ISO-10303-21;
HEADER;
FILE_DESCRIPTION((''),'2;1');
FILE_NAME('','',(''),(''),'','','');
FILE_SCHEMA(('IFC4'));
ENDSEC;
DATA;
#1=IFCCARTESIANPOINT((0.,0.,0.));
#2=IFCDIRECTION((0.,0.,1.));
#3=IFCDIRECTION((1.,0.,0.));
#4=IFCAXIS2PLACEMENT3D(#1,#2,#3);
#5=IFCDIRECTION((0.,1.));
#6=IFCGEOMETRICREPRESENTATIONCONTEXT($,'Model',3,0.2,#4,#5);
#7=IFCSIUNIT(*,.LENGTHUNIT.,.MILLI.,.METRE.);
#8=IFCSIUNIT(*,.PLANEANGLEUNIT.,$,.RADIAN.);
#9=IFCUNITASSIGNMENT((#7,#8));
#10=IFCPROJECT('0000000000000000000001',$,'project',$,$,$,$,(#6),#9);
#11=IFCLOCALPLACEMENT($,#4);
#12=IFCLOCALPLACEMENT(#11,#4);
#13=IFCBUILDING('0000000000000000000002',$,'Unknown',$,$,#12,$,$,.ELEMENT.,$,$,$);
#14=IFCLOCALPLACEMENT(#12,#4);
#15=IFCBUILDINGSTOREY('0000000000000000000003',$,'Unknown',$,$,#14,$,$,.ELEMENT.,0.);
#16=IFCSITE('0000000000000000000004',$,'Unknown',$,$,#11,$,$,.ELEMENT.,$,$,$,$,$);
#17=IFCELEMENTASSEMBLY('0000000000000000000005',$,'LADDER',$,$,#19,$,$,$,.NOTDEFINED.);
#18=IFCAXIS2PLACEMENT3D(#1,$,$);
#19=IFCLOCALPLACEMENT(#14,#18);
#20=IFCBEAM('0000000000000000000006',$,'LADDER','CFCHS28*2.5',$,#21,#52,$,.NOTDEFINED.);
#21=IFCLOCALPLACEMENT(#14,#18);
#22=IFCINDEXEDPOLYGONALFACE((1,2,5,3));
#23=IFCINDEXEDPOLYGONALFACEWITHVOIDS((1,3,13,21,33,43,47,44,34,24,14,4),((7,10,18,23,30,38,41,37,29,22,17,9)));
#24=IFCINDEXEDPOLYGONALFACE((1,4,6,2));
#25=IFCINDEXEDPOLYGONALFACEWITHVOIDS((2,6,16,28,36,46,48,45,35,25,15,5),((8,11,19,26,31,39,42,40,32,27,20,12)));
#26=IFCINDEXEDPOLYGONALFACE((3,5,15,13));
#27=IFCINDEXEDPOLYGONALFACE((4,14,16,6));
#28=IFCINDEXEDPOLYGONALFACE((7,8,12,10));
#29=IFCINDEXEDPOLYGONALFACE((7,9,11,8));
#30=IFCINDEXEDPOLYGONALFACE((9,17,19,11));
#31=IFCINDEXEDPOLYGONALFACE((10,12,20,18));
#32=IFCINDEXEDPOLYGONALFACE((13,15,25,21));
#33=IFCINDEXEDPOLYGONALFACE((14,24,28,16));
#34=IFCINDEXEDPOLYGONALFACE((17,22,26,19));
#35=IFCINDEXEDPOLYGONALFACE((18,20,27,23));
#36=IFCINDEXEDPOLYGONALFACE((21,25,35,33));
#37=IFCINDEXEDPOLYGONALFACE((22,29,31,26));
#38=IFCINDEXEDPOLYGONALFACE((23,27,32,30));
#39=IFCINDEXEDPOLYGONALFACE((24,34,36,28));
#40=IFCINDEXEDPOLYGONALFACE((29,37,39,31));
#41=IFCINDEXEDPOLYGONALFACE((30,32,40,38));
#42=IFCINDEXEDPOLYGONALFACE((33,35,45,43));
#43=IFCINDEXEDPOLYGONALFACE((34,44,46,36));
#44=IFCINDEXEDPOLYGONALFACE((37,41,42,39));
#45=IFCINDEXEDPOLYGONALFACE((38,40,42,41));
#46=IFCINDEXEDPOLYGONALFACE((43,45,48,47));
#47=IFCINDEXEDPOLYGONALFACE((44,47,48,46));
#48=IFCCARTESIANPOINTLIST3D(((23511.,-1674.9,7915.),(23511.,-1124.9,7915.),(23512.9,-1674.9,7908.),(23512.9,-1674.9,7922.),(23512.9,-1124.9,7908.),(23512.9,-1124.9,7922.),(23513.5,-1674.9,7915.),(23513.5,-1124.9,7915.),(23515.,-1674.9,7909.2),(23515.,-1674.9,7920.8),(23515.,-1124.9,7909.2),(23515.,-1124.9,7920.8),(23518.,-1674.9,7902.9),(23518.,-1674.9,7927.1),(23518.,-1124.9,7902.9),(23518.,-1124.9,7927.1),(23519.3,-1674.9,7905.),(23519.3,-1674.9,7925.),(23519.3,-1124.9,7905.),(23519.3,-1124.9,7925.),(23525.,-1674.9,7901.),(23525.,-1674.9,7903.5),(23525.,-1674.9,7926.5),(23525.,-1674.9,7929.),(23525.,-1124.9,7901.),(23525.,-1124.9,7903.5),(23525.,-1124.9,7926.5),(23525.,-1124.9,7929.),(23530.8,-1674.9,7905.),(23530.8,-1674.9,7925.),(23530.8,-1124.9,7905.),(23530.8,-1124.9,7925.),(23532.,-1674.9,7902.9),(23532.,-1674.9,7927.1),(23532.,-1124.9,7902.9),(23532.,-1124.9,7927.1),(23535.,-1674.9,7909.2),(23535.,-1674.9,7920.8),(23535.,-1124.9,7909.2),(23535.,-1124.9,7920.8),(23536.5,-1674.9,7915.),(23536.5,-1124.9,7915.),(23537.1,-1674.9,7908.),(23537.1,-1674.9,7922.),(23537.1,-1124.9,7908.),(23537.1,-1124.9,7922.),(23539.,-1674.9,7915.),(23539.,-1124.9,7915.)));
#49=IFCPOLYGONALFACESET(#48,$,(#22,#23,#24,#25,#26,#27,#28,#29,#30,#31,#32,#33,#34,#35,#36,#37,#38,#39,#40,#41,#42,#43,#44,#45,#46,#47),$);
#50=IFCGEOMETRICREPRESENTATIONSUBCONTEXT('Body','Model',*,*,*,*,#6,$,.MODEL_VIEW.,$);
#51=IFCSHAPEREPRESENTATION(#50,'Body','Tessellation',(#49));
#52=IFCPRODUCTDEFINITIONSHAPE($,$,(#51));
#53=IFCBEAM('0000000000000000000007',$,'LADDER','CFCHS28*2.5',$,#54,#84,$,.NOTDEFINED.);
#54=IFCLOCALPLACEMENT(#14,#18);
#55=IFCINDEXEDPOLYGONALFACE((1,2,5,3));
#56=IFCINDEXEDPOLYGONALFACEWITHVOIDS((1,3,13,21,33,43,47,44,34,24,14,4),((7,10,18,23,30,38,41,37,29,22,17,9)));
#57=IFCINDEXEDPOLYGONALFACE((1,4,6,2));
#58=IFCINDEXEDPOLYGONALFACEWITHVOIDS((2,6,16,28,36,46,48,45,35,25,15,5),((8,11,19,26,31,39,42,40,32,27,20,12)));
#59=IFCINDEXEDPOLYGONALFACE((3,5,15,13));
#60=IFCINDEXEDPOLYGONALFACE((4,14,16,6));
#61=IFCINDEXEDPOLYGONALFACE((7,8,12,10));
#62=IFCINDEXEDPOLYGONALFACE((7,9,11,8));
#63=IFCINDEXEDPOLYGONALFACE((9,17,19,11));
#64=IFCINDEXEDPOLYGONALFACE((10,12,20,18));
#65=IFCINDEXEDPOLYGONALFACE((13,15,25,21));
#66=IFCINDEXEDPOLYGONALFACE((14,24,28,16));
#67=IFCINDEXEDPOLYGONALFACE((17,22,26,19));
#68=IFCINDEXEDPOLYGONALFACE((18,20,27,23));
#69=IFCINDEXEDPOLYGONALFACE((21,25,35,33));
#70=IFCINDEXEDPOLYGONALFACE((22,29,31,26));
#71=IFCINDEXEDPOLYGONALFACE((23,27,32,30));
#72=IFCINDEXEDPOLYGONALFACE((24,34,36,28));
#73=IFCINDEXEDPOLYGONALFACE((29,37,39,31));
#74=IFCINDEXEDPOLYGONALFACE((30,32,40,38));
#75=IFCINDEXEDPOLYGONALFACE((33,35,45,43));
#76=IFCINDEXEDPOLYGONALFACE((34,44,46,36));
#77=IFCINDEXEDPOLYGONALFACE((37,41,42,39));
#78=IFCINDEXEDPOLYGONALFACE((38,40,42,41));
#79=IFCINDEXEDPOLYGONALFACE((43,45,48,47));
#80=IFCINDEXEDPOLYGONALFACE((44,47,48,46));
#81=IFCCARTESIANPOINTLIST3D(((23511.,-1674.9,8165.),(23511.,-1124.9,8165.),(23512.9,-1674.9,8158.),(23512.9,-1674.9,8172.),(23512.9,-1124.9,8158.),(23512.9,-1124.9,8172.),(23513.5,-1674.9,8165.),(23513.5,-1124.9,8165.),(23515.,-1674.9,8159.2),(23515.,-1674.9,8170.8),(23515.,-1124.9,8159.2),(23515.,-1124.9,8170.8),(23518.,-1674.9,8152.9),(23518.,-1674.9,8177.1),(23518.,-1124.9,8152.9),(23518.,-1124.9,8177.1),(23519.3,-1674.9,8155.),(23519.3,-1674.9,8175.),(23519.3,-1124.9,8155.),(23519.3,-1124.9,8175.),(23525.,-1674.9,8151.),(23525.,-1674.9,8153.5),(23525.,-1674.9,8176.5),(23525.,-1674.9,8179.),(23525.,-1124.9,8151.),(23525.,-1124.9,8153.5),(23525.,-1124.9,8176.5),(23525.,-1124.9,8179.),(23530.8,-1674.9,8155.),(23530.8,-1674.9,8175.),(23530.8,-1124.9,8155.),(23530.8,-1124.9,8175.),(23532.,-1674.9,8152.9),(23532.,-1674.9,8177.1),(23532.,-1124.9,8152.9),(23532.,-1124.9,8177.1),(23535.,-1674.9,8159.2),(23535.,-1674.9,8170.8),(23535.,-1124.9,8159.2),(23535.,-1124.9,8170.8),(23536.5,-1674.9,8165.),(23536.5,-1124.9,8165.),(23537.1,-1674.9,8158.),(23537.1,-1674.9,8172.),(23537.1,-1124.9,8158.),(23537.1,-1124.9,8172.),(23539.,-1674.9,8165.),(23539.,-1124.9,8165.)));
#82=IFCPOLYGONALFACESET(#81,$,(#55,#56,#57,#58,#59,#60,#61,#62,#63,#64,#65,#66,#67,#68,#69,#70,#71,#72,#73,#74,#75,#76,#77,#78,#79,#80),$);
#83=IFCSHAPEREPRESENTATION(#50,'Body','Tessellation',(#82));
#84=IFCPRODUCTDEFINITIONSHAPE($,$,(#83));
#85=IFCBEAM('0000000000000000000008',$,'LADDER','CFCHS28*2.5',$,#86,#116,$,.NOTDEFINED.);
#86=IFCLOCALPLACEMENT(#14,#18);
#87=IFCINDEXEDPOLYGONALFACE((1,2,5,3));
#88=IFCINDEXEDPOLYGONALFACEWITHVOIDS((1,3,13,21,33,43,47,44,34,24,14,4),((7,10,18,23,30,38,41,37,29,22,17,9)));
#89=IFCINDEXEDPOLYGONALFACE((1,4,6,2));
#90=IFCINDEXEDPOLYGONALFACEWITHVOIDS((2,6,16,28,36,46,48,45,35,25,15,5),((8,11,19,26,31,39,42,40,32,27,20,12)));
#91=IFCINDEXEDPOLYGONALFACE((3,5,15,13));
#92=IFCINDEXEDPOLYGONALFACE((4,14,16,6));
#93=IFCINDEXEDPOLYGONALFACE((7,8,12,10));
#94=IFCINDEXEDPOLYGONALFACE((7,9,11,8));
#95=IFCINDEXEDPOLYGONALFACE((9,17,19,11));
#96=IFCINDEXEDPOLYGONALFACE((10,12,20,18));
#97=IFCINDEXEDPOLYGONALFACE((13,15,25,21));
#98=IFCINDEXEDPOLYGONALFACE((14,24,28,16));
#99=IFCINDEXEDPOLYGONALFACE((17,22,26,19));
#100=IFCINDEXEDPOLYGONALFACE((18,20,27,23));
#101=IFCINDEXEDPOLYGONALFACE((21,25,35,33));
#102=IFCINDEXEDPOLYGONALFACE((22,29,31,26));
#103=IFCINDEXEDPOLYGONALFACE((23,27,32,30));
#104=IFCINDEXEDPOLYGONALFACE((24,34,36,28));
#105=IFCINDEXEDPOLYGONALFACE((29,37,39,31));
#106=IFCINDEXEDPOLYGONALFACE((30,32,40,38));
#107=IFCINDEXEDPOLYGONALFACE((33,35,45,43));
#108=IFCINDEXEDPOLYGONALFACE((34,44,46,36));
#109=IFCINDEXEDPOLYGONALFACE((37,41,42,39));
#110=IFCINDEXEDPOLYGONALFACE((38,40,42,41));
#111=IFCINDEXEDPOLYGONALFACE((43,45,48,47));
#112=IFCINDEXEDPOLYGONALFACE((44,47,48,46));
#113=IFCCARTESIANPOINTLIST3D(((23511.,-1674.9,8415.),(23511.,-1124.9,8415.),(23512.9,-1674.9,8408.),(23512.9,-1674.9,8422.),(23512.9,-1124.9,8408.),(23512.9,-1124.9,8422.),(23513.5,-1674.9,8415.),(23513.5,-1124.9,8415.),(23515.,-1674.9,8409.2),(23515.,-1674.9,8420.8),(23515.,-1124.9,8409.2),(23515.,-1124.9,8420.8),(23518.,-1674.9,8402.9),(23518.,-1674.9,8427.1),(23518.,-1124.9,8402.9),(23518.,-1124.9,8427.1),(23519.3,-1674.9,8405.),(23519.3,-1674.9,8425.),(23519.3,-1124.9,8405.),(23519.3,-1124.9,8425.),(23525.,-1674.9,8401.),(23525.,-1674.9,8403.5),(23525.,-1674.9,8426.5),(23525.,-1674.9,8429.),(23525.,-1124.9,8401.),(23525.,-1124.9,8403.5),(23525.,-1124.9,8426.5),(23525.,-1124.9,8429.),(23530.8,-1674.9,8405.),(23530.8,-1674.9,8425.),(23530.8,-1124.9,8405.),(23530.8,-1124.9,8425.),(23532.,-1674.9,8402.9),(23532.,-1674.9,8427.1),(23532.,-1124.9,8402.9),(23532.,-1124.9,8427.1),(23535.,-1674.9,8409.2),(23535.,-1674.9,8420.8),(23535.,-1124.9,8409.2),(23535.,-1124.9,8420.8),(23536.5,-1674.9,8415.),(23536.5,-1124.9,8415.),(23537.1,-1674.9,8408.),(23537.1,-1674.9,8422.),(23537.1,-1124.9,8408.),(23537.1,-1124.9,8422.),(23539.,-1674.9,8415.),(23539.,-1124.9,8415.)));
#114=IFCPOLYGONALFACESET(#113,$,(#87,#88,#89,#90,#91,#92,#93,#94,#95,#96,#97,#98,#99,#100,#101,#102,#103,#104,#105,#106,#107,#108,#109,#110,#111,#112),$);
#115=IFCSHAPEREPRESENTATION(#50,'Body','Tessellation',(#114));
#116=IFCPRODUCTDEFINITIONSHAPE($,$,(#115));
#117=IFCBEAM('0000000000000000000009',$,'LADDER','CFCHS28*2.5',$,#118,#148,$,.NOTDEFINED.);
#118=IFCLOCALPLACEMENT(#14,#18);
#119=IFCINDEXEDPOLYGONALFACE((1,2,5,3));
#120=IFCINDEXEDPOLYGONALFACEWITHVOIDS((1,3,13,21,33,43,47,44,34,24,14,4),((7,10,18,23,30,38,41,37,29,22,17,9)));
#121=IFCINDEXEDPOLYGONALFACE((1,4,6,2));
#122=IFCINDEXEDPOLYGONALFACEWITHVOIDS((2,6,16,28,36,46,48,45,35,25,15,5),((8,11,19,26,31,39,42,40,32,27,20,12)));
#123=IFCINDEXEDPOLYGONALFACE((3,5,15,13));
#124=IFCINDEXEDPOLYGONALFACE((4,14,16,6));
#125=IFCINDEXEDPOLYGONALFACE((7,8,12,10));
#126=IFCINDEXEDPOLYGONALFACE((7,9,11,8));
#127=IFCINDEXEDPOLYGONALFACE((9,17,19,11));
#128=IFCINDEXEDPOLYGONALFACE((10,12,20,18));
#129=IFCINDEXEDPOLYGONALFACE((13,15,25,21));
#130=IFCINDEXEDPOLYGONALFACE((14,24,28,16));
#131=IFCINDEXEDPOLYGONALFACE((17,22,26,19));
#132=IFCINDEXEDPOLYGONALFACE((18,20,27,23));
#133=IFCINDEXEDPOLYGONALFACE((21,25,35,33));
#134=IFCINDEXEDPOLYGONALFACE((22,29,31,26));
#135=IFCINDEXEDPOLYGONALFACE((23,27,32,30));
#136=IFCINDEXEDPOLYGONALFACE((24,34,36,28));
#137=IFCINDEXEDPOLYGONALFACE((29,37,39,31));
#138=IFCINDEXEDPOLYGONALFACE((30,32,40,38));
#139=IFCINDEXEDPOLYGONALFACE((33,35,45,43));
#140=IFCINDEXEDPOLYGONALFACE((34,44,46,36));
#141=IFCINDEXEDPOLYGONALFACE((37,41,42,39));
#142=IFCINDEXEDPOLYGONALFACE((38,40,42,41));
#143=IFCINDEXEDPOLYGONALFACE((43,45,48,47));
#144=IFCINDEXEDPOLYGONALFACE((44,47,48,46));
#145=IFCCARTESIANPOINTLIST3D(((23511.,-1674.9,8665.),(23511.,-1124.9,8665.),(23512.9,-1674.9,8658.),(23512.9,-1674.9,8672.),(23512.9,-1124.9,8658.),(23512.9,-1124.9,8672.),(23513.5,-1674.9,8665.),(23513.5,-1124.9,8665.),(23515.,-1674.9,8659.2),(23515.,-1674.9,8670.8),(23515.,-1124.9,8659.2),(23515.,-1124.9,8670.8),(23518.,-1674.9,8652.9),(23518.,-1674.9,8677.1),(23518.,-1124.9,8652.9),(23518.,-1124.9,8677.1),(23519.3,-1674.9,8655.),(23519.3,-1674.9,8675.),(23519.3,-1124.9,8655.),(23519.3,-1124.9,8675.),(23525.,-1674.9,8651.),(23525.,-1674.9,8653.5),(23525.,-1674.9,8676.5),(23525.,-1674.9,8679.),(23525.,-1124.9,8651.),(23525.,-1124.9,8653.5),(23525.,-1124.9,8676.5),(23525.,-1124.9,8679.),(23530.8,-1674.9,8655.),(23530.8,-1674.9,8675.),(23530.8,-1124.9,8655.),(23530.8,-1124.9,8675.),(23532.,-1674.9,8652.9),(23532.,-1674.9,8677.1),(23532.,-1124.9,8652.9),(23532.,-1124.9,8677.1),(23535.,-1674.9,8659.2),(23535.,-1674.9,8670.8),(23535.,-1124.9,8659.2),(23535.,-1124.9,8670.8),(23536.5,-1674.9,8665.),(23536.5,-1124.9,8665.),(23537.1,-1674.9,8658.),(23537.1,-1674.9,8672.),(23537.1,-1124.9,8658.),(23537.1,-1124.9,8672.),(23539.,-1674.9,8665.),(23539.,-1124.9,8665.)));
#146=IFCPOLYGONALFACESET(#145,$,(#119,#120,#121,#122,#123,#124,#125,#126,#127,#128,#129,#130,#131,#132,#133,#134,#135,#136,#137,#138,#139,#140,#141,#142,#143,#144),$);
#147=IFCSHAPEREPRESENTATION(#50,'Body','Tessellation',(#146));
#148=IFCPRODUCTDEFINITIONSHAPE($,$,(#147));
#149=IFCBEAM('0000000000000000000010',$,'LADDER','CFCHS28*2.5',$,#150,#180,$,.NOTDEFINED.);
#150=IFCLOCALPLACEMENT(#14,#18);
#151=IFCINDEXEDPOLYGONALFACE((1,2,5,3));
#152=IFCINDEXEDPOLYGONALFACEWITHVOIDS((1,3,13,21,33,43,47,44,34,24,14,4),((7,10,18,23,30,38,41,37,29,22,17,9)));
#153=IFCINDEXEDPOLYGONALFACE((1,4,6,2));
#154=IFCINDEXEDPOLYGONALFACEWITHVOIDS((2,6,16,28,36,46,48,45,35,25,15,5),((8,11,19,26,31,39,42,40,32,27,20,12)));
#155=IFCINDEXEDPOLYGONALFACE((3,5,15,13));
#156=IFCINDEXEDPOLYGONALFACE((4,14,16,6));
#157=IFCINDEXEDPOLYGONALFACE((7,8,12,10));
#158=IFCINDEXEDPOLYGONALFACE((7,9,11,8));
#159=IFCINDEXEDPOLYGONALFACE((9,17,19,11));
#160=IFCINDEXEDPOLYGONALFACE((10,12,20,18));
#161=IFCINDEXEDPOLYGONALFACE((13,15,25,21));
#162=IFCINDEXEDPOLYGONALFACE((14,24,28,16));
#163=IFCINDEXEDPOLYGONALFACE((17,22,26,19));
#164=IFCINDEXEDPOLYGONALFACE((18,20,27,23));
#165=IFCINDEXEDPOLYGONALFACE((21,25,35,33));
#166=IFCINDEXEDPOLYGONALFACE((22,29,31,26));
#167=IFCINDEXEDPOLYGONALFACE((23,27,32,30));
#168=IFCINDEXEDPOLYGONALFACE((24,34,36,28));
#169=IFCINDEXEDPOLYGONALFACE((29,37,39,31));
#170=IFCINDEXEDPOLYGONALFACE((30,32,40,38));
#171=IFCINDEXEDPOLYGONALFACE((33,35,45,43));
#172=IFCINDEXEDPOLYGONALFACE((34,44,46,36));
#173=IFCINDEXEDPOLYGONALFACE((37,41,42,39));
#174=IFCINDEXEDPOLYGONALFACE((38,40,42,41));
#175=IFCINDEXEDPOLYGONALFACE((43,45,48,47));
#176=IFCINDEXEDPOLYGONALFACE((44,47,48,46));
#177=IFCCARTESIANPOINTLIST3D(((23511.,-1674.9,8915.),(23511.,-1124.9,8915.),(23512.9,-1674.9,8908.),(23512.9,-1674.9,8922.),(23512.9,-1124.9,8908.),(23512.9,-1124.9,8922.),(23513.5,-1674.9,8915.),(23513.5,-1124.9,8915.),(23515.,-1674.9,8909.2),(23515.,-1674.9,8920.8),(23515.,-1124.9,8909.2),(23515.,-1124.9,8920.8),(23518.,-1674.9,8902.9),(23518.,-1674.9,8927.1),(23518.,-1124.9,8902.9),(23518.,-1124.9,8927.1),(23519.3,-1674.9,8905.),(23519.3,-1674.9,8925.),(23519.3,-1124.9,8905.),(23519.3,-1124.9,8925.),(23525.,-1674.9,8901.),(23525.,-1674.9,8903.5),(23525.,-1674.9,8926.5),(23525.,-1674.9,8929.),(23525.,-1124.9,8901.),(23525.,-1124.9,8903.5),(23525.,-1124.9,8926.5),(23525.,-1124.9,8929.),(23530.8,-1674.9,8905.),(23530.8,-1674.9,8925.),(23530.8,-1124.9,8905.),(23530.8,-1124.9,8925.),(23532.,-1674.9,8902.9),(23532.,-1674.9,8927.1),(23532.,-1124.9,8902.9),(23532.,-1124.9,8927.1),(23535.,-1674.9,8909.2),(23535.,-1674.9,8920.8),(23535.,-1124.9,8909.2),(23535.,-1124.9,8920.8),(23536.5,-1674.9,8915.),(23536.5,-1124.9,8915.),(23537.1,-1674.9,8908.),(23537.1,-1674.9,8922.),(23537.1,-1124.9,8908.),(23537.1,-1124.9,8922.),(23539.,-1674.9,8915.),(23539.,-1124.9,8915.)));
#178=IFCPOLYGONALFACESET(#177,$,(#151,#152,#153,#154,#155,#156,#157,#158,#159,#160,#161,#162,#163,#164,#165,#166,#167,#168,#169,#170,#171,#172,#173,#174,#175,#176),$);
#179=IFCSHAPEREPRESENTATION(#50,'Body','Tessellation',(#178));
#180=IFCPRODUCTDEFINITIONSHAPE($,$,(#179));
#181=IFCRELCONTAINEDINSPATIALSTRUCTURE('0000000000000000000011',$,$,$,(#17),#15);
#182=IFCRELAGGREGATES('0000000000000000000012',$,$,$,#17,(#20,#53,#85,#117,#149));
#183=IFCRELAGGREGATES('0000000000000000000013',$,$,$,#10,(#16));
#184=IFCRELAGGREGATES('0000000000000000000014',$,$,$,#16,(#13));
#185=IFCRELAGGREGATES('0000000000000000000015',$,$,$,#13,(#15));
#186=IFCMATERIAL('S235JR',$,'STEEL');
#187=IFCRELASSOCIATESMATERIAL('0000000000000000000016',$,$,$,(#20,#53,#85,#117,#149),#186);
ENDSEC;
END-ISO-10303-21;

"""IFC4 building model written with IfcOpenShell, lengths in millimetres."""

from ifc_helpers import new_model, si_unit, direction, frame, origin_with_axes, place, context, subcontext, project, spatial, line, indexed_curve, outline, extrude, material, element, aggregate, save


model = new_model("IFC4")

# Units and contexts
model_context = context("Model", 3, precision=0.2, world=origin_with_axes(), true_north=direction((0.0, 1.0)))
body_context = subcontext(model_context, "Body", "Model", "MODEL_VIEW")
ifc_project = project(units=[si_unit("LENGTHUNIT", "METRE", prefix="MILLI"), si_unit("PLANEANGLEUNIT", "RADIAN")], contexts=[model_context])

# Site, building, storey
site_placement = place(None, origin_with_axes())
site = spatial("IfcSite", under=ifc_project, at=site_placement, Name="Unknown", CompositionType="ELEMENT")
building_placement = place(site_placement, origin_with_axes())
building = spatial("IfcBuilding", under=site, at=building_placement, Name="Unknown", CompositionType="ELEMENT")
storey_placement = place(building_placement, origin_with_axes())
storey = spatial("IfcBuildingStorey", under=building, at=storey_placement, Name="Unknown", CompositionType="ELEMENT", Elevation=0.0)

# Element assembly, beams
assembly_1_placement = place(storey_placement, frame((23525.0, -1699.9, 5175.0), z_axis=(0.0, 1.0, 0.0), x_axis=(0.0, 0.0, 1.0)))
assembly_1 = element("IfcElementAssembly", 1, at=assembly_1_placement, inside=storey, Name="LADDER", PredefinedType="NOTDEFINED")
ifc_material = material(Name="S235JR", Category="STEEL")
beam_1_placement = place(assembly_1_placement, frame((2740.0, 0.0, 25.0), z_axis=(0.0, -1.0, 0.0), x_axis=(0.0, 0.0, 1.0)))
beam_1 = element("IfcBeam", 2, at=beam_1_placement, material=ifc_material, Name="LADDER", Description="CFCHS28*2.5", PredefinedType="NOTDEFINED", context=body_context, shape_type="SolidModel", body=[
    extrude(outline(indexed_curve([(14.0, 0.0), (12.1, 7.0), (7.0, 12.1), (0.0, 14.0), (-7.0, 12.1), (-12.1, 7.0), (-14.0, 0.0), (-12.1, -7.0), (-7.0, -12.1), (0.0, -14.0), (7.0, -12.1), (12.1, -7.0)], segments=[line(1, 2, 3, 4, 5, 6, 7, 8, 9, 10, 11, 12, 1)]), holes=[indexed_curve([(11.5, 0.0), (10.0, -5.8), (5.8, -10.0), (0.0, -11.5), (-5.8, -10.0), (-10.0, -5.8), (-11.5, 0.0), (-10.0, 5.8), (-5.8, 10.0), (0.0, 11.5), (5.8, 10.0), (10.0, 5.8)], segments=[line(1, 2, 3, 4, 5, 6, 7, 8, 9, 10, 11, 12, 1)])]), frame((0.0, 0.0, 0.0), z_axis=(-1.0, 0.0, 0.0), x_axis=(0.0, 0.0, 1.0)), (0.0, 0.0, -1.0), 550.0),
])
beam_2_placement = place(assembly_1_placement, frame((2990.0, 0.0, 25.0), z_axis=(0.0, -1.0, 0.0), x_axis=(0.0, 0.0, 1.0)))
beam_2 = element("IfcBeam", 3, at=beam_2_placement, material=ifc_material, Name="LADDER", Description="CFCHS28*2.5", PredefinedType="NOTDEFINED", context=body_context, shape_type="SolidModel", body=[
    extrude(outline(indexed_curve([(14.0, 0.0), (12.1, 7.0), (7.0, 12.1), (0.0, 14.0), (-7.0, 12.1), (-12.1, 7.0), (-14.0, 0.0), (-12.1, -7.0), (-7.0, -12.1), (0.0, -14.0), (7.0, -12.1), (12.1, -7.0)], segments=[line(1, 2, 3, 4, 5, 6, 7, 8, 9, 10, 11, 12, 1)]), holes=[indexed_curve([(11.5, 0.0), (10.0, -5.8), (5.8, -10.0), (0.0, -11.5), (-5.8, -10.0), (-10.0, -5.8), (-11.5, 0.0), (-10.0, 5.8), (-5.8, 10.0), (0.0, 11.5), (5.8, 10.0), (10.0, 5.8)], segments=[line(1, 2, 3, 4, 5, 6, 7, 8, 9, 10, 11, 12, 1)])]), frame((0.0, 0.0, 0.0), z_axis=(-1.0, 0.0, 0.0), x_axis=(0.0, 0.0, 1.0)), (0.0, 0.0, -1.0), 550.0),
])
beam_3_placement = place(assembly_1_placement, frame((3240.0, 0.0, 25.0), z_axis=(0.0, -1.0, 0.0), x_axis=(0.0, 0.0, 1.0)))
beam_3 = element("IfcBeam", 4, at=beam_3_placement, material=ifc_material, Name="LADDER", Description="CFCHS28*2.5", PredefinedType="NOTDEFINED", context=body_context, shape_type="SolidModel", body=[
    extrude(outline(indexed_curve([(14.0, 0.0), (12.1, 7.0), (7.0, 12.1), (0.0, 14.0), (-7.0, 12.1), (-12.1, 7.0), (-14.0, 0.0), (-12.1, -7.0), (-7.0, -12.1), (0.0, -14.0), (7.0, -12.1), (12.1, -7.0)], segments=[line(1, 2, 3, 4, 5, 6, 7, 8, 9, 10, 11, 12, 1)]), holes=[indexed_curve([(11.5, 0.0), (10.0, -5.8), (5.8, -10.0), (0.0, -11.5), (-5.8, -10.0), (-10.0, -5.8), (-11.5, 0.0), (-10.0, 5.8), (-5.8, 10.0), (0.0, 11.5), (5.8, 10.0), (10.0, 5.8)], segments=[line(1, 2, 3, 4, 5, 6, 7, 8, 9, 10, 11, 12, 1)])]), frame((0.0, 0.0, 0.0), z_axis=(-1.0, 0.0, 0.0), x_axis=(0.0, 0.0, 1.0)), (0.0, 0.0, -1.0), 550.0),
])
beam_4_placement = place(assembly_1_placement, frame((3490.0, 0.0, 25.0), z_axis=(0.0, -1.0, 0.0), x_axis=(0.0, 0.0, 1.0)))
beam_4 = element("IfcBeam", 5, at=beam_4_placement, material=ifc_material, Name="LADDER", Description="CFCHS28*2.5", PredefinedType="NOTDEFINED", context=body_context, shape_type="SolidModel", body=[
    extrude(outline(indexed_curve([(14.0, 0.0), (12.1, 7.0), (7.0, 12.1), (0.0, 14.0), (-7.0, 12.1), (-12.1, 7.0), (-14.0, 0.0), (-12.1, -7.0), (-7.0, -12.1), (0.0, -14.0), (7.0, -12.1), (12.1, -7.0)], segments=[line(1, 2, 3, 4, 5, 6, 7, 8, 9, 10, 11, 12, 1)]), holes=[indexed_curve([(11.5, 0.0), (10.0, -5.8), (5.8, -10.0), (0.0, -11.5), (-5.8, -10.0), (-10.0, -5.8), (-11.5, 0.0), (-10.0, 5.8), (-5.8, 10.0), (0.0, 11.5), (5.8, 10.0), (10.0, 5.8)], segments=[line(1, 2, 3, 4, 5, 6, 7, 8, 9, 10, 11, 12, 1)])]), frame((0.0, 0.0, 0.0), z_axis=(-1.0, 0.0, 0.0), x_axis=(0.0, 0.0, 1.0)), (0.0, 0.0, -1.0), 550.0),
])
beam_5_placement = place(assembly_1_placement, frame((3740.0, 0.0, 25.0), z_axis=(0.0, -1.0, 0.0), x_axis=(0.0, 0.0, 1.0)))
beam_5 = element("IfcBeam", 6, at=beam_5_placement, material=ifc_material, Name="LADDER", Description="CFCHS28*2.5", PredefinedType="NOTDEFINED", context=body_context, shape_type="SolidModel", body=[
    extrude(outline(indexed_curve([(14.0, 0.0), (12.1, 7.0), (7.0, 12.1), (0.0, 14.0), (-7.0, 12.1), (-12.1, 7.0), (-14.0, 0.0), (-12.1, -7.0), (-7.0, -12.1), (0.0, -14.0), (7.0, -12.1), (12.1, -7.0)], segments=[line(1, 2, 3, 4, 5, 6, 7, 8, 9, 10, 11, 12, 1)]), holes=[indexed_curve([(11.5, 0.0), (10.0, -5.8), (5.8, -10.0), (0.0, -11.5), (-5.8, -10.0), (-10.0, -5.8), (-11.5, 0.0), (-10.0, 5.8), (-5.8, 10.0), (0.0, 11.5), (5.8, 10.0), (10.0, 5.8)], segments=[line(1, 2, 3, 4, 5, 6, 7, 8, 9, 10, 11, 12, 1)])]), frame((0.0, 0.0, 0.0), z_axis=(-1.0, 0.0, 0.0), x_axis=(0.0, 0.0, 1.0)), (0.0, 0.0, -1.0), 550.0),
])
aggregate(assembly_1, [beam_1, beam_2, beam_3, beam_4, beam_5])

save(model, "model.ifc")
